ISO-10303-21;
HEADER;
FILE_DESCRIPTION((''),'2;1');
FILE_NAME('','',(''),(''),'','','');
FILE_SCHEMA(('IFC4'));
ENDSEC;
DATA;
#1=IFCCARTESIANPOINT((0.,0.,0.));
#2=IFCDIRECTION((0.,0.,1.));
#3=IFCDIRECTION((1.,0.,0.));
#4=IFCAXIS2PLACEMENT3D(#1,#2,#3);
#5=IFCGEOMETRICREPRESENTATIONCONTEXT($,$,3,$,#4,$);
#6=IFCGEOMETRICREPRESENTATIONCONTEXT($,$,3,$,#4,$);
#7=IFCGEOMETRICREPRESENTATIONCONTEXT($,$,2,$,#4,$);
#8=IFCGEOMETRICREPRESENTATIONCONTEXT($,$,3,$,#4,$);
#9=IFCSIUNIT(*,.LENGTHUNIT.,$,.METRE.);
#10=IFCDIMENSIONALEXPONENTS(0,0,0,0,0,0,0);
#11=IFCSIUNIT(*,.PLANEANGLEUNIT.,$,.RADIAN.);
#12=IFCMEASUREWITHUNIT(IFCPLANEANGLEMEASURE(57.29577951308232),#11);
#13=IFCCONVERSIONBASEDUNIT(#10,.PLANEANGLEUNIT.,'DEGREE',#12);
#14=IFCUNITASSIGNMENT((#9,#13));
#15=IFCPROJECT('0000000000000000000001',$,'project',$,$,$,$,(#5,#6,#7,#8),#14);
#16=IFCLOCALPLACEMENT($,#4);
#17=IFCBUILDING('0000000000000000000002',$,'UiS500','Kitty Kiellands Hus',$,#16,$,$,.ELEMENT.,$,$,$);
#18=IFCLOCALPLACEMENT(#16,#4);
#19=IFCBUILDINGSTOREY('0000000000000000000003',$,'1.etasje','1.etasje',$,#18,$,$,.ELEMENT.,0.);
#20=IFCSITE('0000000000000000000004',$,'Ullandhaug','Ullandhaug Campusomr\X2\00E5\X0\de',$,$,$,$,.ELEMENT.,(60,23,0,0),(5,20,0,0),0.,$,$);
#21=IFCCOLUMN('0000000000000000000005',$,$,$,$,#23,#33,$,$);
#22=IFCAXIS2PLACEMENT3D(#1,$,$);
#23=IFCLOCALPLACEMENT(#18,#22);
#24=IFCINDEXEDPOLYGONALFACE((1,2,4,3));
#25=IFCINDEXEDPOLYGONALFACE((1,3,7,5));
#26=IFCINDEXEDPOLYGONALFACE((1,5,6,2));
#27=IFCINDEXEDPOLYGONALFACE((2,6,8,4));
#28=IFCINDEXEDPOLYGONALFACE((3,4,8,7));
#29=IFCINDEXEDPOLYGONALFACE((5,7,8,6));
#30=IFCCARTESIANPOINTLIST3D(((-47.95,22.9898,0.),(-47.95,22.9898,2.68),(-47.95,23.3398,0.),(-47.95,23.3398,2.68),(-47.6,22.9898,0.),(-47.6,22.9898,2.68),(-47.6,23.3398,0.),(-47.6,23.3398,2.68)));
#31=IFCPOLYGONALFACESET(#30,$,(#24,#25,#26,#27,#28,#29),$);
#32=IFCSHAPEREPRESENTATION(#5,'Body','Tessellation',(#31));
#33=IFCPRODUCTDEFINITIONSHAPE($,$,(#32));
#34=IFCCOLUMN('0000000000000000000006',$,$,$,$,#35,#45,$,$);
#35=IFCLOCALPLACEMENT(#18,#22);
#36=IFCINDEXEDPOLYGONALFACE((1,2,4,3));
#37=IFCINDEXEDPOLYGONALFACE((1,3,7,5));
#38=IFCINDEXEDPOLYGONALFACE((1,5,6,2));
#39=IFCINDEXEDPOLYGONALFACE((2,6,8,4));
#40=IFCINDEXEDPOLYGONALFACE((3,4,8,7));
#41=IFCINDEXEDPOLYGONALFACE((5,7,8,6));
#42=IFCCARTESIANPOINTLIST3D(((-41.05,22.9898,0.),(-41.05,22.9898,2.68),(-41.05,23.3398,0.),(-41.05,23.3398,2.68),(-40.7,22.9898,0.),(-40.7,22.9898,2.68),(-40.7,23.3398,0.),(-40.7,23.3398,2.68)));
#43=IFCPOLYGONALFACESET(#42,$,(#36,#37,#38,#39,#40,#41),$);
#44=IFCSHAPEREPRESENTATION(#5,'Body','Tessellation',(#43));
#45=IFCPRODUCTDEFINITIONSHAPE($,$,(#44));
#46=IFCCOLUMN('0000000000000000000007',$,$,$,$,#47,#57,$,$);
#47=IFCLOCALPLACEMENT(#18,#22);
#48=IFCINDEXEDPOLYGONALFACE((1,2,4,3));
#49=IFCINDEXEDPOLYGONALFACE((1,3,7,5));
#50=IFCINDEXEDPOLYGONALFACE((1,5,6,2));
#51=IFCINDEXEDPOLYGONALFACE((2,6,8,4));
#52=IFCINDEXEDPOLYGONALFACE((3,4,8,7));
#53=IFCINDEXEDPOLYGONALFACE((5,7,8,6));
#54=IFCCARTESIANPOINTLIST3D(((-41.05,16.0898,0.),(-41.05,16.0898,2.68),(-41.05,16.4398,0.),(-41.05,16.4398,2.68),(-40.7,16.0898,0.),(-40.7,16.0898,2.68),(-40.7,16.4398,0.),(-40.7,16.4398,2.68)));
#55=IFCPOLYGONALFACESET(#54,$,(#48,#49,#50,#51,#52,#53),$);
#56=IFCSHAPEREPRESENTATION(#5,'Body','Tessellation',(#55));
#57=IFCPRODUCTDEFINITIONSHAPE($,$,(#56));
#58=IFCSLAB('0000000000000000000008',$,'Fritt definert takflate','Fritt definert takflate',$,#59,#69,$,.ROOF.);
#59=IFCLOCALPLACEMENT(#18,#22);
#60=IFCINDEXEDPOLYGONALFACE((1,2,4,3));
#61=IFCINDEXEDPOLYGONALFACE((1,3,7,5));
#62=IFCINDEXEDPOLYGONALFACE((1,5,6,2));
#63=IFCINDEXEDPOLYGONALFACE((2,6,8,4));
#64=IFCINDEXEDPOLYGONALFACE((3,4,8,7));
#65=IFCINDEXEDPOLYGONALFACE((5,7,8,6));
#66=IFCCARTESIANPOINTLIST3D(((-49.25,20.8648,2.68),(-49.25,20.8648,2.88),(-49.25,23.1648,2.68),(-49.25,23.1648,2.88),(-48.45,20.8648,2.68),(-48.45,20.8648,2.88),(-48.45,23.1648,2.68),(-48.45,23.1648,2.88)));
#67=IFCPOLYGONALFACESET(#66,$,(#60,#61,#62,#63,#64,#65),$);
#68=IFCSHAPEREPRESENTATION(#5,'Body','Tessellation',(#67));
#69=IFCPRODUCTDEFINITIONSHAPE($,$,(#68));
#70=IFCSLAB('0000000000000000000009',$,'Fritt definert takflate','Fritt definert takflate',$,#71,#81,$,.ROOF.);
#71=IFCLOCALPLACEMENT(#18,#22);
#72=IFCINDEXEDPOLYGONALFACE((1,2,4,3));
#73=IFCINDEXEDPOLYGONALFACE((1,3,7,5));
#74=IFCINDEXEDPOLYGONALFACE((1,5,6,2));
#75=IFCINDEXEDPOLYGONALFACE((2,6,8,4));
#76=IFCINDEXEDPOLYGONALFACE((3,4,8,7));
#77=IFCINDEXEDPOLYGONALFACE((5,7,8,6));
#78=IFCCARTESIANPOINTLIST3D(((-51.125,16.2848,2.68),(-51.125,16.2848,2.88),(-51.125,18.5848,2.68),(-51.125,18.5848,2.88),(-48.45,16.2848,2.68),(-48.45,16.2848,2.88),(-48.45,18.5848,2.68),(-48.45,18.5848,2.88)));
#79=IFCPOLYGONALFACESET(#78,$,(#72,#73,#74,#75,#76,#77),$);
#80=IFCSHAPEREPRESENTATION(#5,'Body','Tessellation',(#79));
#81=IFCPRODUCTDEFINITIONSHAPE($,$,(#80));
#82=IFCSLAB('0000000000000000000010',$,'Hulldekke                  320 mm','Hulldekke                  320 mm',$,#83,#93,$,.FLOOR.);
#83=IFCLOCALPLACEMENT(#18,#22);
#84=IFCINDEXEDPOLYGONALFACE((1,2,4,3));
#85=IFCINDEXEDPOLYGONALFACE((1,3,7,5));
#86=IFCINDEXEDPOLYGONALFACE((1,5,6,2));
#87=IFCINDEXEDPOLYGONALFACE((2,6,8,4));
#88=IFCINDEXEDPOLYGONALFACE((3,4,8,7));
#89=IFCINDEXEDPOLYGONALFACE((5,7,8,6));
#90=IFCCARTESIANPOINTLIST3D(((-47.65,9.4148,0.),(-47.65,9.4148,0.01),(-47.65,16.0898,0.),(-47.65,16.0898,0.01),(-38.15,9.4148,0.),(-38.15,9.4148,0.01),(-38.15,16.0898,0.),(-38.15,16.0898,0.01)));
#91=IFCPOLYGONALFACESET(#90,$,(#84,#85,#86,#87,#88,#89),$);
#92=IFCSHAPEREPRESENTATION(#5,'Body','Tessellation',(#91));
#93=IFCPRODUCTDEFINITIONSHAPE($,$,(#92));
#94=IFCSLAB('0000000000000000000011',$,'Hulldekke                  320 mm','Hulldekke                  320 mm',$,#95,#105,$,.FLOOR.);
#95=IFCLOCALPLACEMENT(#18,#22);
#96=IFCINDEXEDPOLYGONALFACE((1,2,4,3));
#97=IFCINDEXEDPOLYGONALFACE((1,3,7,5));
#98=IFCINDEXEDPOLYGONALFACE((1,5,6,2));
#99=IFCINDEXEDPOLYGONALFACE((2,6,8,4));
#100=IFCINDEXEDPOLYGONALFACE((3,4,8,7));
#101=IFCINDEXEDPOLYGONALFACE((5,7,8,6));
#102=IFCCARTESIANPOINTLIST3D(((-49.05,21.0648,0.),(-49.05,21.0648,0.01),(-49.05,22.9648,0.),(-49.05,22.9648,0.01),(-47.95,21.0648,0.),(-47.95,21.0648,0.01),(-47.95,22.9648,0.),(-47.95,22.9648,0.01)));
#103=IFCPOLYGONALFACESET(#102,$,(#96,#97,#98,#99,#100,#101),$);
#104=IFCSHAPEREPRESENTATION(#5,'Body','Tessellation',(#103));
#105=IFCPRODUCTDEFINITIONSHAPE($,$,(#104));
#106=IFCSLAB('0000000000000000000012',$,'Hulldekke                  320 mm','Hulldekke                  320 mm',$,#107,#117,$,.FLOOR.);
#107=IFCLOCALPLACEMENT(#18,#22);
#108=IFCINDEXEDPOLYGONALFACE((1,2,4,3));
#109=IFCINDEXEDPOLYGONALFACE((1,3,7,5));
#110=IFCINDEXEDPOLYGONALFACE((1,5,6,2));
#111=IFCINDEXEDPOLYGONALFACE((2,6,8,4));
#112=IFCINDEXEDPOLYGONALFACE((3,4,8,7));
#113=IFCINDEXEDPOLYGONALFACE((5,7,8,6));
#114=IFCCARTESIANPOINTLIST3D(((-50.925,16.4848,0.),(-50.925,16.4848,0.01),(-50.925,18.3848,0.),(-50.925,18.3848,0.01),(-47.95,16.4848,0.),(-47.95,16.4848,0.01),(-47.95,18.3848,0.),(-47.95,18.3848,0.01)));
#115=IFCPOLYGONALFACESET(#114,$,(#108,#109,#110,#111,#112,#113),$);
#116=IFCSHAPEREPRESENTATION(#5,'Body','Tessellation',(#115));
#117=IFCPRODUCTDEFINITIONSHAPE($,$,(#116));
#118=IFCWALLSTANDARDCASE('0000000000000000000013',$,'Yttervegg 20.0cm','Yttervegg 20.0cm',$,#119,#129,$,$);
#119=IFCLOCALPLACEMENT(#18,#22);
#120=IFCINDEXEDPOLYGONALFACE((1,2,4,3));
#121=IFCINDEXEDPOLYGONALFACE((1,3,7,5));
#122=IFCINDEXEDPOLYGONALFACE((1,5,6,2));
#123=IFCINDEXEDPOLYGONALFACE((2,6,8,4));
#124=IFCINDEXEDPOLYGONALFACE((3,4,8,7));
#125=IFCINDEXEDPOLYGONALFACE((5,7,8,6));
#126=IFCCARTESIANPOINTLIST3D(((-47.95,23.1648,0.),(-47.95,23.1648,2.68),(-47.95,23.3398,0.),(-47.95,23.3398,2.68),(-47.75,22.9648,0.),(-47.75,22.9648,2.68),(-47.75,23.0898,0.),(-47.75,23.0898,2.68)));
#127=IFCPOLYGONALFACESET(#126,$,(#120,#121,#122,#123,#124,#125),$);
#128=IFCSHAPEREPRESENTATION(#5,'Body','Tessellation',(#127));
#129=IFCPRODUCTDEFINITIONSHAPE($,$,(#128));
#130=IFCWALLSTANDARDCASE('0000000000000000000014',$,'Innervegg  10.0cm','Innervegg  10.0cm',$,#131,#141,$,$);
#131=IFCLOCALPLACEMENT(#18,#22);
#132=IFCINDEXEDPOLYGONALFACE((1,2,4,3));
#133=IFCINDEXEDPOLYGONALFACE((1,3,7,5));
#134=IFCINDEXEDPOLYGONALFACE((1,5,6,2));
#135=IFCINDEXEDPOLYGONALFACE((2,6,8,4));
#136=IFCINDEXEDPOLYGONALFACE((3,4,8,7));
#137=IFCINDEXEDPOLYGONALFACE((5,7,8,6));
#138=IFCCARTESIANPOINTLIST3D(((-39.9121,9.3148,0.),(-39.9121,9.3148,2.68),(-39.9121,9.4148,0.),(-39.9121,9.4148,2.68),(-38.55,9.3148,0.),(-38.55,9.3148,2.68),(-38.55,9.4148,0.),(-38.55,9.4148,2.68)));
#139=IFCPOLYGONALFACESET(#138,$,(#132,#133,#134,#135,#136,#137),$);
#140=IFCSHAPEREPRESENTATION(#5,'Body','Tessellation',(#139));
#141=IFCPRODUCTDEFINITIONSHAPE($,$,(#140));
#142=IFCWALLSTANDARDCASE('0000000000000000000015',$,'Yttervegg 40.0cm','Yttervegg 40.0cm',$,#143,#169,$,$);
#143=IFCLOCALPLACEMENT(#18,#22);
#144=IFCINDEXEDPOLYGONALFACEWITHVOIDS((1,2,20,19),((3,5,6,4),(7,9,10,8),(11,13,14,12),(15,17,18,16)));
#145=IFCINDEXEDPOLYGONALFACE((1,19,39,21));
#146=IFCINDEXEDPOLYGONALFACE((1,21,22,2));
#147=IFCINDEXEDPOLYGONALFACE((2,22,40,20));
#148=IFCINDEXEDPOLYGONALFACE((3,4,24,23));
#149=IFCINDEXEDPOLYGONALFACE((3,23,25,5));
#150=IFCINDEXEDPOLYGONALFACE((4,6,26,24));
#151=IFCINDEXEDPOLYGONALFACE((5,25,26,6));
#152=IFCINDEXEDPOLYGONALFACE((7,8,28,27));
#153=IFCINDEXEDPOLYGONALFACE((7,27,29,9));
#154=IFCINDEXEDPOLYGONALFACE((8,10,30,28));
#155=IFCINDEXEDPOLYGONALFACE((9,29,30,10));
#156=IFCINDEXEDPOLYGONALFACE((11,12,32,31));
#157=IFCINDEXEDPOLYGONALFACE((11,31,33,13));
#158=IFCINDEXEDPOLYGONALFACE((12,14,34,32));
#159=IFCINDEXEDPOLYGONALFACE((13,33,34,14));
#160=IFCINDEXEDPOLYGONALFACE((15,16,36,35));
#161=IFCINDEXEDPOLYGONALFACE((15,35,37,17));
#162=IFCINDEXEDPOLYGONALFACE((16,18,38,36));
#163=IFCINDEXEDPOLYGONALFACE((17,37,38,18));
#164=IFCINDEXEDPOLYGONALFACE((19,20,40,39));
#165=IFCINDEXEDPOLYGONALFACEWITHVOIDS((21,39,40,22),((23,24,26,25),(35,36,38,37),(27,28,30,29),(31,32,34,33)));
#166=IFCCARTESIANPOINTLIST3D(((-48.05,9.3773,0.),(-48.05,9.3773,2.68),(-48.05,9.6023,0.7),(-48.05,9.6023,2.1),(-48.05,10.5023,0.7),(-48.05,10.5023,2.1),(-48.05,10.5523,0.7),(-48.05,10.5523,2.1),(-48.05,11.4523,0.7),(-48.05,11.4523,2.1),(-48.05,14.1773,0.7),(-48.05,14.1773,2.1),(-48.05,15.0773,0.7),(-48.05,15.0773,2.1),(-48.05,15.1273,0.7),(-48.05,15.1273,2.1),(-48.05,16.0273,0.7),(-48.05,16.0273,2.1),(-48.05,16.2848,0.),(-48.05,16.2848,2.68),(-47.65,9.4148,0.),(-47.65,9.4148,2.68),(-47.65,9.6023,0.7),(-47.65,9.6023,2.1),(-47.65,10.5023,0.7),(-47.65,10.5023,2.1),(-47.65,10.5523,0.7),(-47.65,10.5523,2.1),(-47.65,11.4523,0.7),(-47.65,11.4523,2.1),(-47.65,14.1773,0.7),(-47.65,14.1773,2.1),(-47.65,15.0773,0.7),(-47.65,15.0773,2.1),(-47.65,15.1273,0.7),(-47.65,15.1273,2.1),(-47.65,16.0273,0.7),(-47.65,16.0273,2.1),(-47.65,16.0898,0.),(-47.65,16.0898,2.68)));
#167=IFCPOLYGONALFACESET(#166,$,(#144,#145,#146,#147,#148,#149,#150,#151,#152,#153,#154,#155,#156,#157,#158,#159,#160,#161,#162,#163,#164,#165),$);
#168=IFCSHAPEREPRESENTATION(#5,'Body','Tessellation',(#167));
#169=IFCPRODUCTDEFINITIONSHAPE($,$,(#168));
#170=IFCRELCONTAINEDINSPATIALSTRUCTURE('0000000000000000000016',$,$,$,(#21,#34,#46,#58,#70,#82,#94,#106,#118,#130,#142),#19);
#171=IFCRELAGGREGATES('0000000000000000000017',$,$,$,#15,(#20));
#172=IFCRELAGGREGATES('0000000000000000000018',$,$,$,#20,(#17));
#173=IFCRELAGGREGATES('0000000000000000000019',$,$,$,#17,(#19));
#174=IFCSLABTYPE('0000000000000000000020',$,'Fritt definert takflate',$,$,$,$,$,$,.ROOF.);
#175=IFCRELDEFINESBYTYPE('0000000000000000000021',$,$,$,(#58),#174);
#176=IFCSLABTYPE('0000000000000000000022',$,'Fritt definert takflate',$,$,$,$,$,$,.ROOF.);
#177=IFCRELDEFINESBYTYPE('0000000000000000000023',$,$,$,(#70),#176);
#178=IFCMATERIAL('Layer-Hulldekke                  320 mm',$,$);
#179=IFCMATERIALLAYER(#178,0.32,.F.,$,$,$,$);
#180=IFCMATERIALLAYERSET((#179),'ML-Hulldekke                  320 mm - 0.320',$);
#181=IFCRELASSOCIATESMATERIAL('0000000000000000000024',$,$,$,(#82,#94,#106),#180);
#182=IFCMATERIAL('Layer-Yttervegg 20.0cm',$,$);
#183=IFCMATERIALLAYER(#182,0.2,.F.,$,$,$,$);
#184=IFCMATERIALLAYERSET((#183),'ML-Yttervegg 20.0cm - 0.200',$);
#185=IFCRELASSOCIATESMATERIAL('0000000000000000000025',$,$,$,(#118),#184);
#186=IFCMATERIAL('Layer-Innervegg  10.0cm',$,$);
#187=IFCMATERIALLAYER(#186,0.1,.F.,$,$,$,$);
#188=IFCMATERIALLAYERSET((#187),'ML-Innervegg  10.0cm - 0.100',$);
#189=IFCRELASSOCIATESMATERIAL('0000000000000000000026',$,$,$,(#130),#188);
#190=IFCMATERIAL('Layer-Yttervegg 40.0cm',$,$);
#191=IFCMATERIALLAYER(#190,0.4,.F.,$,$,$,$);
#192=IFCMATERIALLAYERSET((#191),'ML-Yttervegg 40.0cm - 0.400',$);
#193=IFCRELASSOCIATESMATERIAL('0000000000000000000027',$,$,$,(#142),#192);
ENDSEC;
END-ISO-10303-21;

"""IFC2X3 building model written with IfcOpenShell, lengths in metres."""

from ifc_helpers import new_model, entity, si_unit, converted_unit, frame, origin_with_axes, origin_2d_with_axis, place, context, project, spatial, polyline, rectangle, outline, extrude, material, layer, layer_set, layer_usage, type_object, element, save


model = new_model("IFC2X3")

# Units and contexts
context_of_model_1 = context(None, 3, world=origin_with_axes())
context_of_model_2 = context(None, 3, world=origin_with_axes())
context_of_model_3 = context(None, 2, world=origin_with_axes())
context_of_model_4 = context(None, 3, world=origin_with_axes())
ifc_project = project(units=[si_unit("LENGTHUNIT", "METRE"), converted_unit("PLANEANGLEUNIT", "DEGREE", entity("IfcPlaneAngleMeasure", 57.29577951308232), si_unit("PLANEANGLEUNIT", "RADIAN"), dimensions=[0, 0, 0, 0, 0, 0, 0])], contexts=[context_of_model_1, context_of_model_2, context_of_model_3, context_of_model_4])

# Site, building, storey
site = spatial("IfcSite", under=ifc_project, Name="Ullandhaug", Description="Ullandhaug Campusområde", CompositionType="ELEMENT", RefLatitude=(60, 23, 0, 0), RefLongitude=(5, 20, 0, 0), RefElevation=0.0)
building_placement = place(None, origin_with_axes())
building = spatial("IfcBuilding", under=site, at=building_placement, Name="UiS500", Description="Kitty Kiellands Hus", CompositionType="ELEMENT")
storey_placement = place(building_placement, origin_with_axes())
storey = spatial("IfcBuildingStorey", under=building, at=storey_placement, Name="1.etasje", Description="1.etasje", CompositionType="ELEMENT", Elevation=0.0)

# Columns
for number, where, z_axis, x_axis in (
    (1, (-47.775, 23.1648, 0.0), (0.0, 0.0, 1.0), (1.0, 0.0, 0.0)),
    (2, (-40.875, 23.1648, 0.0), (0.0, 0.0, 1.0), (1.0, 0.0, 0.0)),
    (3, (-40.875, 16.2648, 0.0), (0.0, 0.0, 1.0), (1.0, 0.0, 0.0)),
):
    element("IfcColumn", number, at=place(storey_placement, frame(where, z_axis=z_axis, x_axis=x_axis)), inside=storey, context=context_of_model_1, shape_type="SweptSolid", body=[
        extrude(rectangle(XDim=0.35, YDim=0.35, at=origin_2d_with_axis()), origin_with_axes(), (0.0, 0.0, 1.0), 2.68),
    ])

# Slabs
slab_type_1 = type_object("IfcSlabType", Name="Fritt definert takflate", PredefinedType="ROOF")
slab_1_placement = place(storey_placement, frame((-48.45, 23.1648, 2.68), z_axis=(0.0, 0.0, 1.0), x_axis=(-1.0, 0.0, 0.0)))
element("IfcSlab", 4, at=slab_1_placement, inside=storey, type_object=slab_type_1, Name="Fritt definert takflate", Description="Fritt definert takflate", PredefinedType="ROOF", context=context_of_model_1, shape_type="SweptSolid", body=[
    extrude(outline(polyline([(0.0, 0.0), (0.8, 0.0), (0.8, 2.3), (0.0, 2.3), (0.0, 0.0)])), origin_with_axes(), (0.0, 0.0, 1.0), 0.2),
])
slab_type_2 = type_object("IfcSlabType", Name="Fritt definert takflate", PredefinedType="ROOF")
slab_2_placement = place(storey_placement, frame((-48.45, 18.5848, 2.68), z_axis=(0.0, 0.0, 1.0), x_axis=(-1.0, 0.0, 0.0)))
element("IfcSlab", 5, at=slab_2_placement, inside=storey, type_object=slab_type_2, Name="Fritt definert takflate", Description="Fritt definert takflate", PredefinedType="ROOF", context=context_of_model_1, shape_type="SweptSolid", body=[
    extrude(outline(polyline([(0.0, 0.0), (2.675, 0.0), (2.675, 2.3), (0.0, 2.3), (0.0, 0.0)])), origin_with_axes(), (0.0, 0.0, 1.0), 0.2),
])
ifc_material_1 = material(Name="Layer-Hulldekke                  320 mm")
ifc_layer_1 = layer(ifc_material_1, 0.32, ventilated=False)
ifc_layer_set_1 = layer_set([ifc_layer_1], Name="ML-Hulldekke                  320 mm - 0.320")
ifc_layer_usage_1 = layer_usage(ifc_layer_set_1, "AXIS2", "POSITIVE", 0.0)
slab_3_placement = place(storey_placement, frame((-47.65, 16.0898, 0.0), z_axis=(0.0, 0.0, 1.0), x_axis=(1.0, 0.0, 0.0)))
element("IfcSlab", 6, at=slab_3_placement, inside=storey, material=ifc_layer_usage_1, Name="Hulldekke                  320 mm", Description="Hulldekke                  320 mm", PredefinedType="FLOOR", context=context_of_model_1, shape_type="SweptSolid", body=[
    extrude(outline(polyline([(0.0, 0.0), (6.675, 0.0), (6.675, 9.5), (0.0, 9.5), (0.0, 0.0)])), frame((0.0, 0.0, 0.0), z_axis=(0.0, 0.0, 1.0), x_axis=(0.0, -1.0, 0.0)), (0.0, 0.0, 1.0), 0.01),
])
slab_4_placement = place(storey_placement, frame((-49.05, 22.9648, 0.0), z_axis=(0.0, 0.0, 1.0), x_axis=(1.0, 0.0, 0.0)))
element("IfcSlab", 7, at=slab_4_placement, inside=storey, material=ifc_layer_usage_1, Name="Hulldekke                  320 mm", Description="Hulldekke                  320 mm", PredefinedType="FLOOR", context=context_of_model_1, shape_type="SweptSolid", body=[
    extrude(outline(polyline([(0.0, 0.0), (1.9, 0.0), (1.9, 1.1), (0.0, 1.1), (0.0, 0.0)])), frame((0.0, 0.0, 0.0), z_axis=(0.0, 0.0, 1.0), x_axis=(0.0, -1.0, 0.0)), (0.0, 0.0, 1.0), 0.01),
])
slab_5_placement = place(storey_placement, frame((-50.925, 16.4848, 0.0), z_axis=(0.0, 0.0, 1.0), x_axis=(1.0, 0.0, 0.0)))
element("IfcSlab", 8, at=slab_5_placement, inside=storey, material=ifc_layer_usage_1, Name="Hulldekke                  320 mm", Description="Hulldekke                  320 mm", PredefinedType="FLOOR", context=context_of_model_1, shape_type="SweptSolid", body=[
    extrude(outline(polyline([(0.0, 0.0), (2.975, 0.0), (2.975, 1.9), (0.0, 1.9), (0.0, 0.0)])), origin_with_axes(), (0.0, 0.0, 1.0), 0.01),
])

# Walls
ifc_material_2 = material(Name="Layer-Yttervegg 20.0cm")
ifc_layer_2 = layer(ifc_material_2, 0.2, ventilated=False)
ifc_layer_set_2 = layer_set([ifc_layer_2], Name="ML-Yttervegg 20.0cm - 0.200")
ifc_layer_usage_2 = layer_usage(ifc_layer_set_2, "AXIS2", "POSITIVE", 0.0)
wall_1_placement = place(storey_placement, frame((-47.95, 23.3398, 0.0), z_axis=(0.0, 0.0, 1.0), x_axis=(0.0, -1.0, 0.0)))
element("IfcWallStandardCase", 9, at=wall_1_placement, inside=storey, material=ifc_layer_usage_2, Name="Yttervegg 20.0cm", Description="Yttervegg 20.0cm", context=context_of_model_1, shape_type="SweptSolid", body=[
    extrude(outline(polyline([(0.0, 0.0), (0.175, 0.0), (0.375, 0.2), (0.25, 0.2), (0.0, 0.0)])), frame((0.0, 0.0, 0.0), z_axis=(0.0, 0.0, 1.0), x_axis=(1.0, 0.0, 0.0)), (0.0, 0.0, 1.0), 2.68),
])
ifc_material_3 = material(Name="Layer-Innervegg  10.0cm")
ifc_layer_3 = layer(ifc_material_3, 0.1, ventilated=False)
ifc_layer_set_3 = layer_set([ifc_layer_3], Name="ML-Innervegg  10.0cm - 0.100")
ifc_layer_usage_3 = layer_usage(ifc_layer_set_3, "AXIS2", "POSITIVE", 0.0)
wall_2_placement = place(storey_placement, frame((-38.55, 9.4148, 0.0), z_axis=(0.0, 0.0, 1.0), x_axis=(-1.0, 0.0, 0.0)))
element("IfcWallStandardCase", 10, at=wall_2_placement, inside=storey, material=ifc_layer_usage_3, Name="Innervegg  10.0cm", Description="Innervegg  10.0cm", context=context_of_model_1, shape_type="SweptSolid", body=[
    extrude(outline(polyline([(0.0, 0.0), (1.3621, 0.0), (1.3621, 0.1), (0.0, 0.1), (0.0, 0.0)])), frame((0.0, 0.0, 0.0), z_axis=(0.0, 0.0, 1.0), x_axis=(1.0, 0.0, 0.0)), (0.0, 0.0, 1.0), 2.68),
])

# Wall, openings
ifc_material_4 = material(Name="Layer-Yttervegg 40.0cm")
ifc_layer_4 = layer(ifc_material_4, 0.4, ventilated=False)
ifc_layer_set_4 = layer_set([ifc_layer_4], Name="ML-Yttervegg 40.0cm - 0.400")
ifc_layer_usage_4 = layer_usage(ifc_layer_set_4, "AXIS2", "POSITIVE", 0.0)
wall_3_placement = place(storey_placement, frame((-48.05, 16.2848, 0.0), z_axis=(0.0, 0.0, 1.0), x_axis=(0.0, -1.0, 0.0)))
wall_3 = element("IfcWallStandardCase", 11, at=wall_3_placement, inside=storey, material=ifc_layer_usage_4, Name="Yttervegg 40.0cm", Description="Yttervegg 40.0cm", context=context_of_model_1, shape_type="SweptSolid", body=[
    extrude(outline(polyline([(0.0, 0.0), (6.9075, 0.0), (6.87, 0.4), (0.195, 0.4), (0.0, 0.0)])), frame((0.0, 0.0, 0.0), z_axis=(0.0, 0.0, 1.0), x_axis=(1.0, 0.0, 0.0)), (0.0, 0.0, 1.0), 2.68),
])
opening_1_placement = place(wall_3_placement, frame((5.7825, 0.4, 0.7), z_axis=(0.0, 0.0, 1.0), x_axis=(1.0, 0.0, 0.0)))
element("IfcOpeningElement", 12, at=opening_1_placement, cuts=wall_3, context=context_of_model_1, shape_type="SweptSolid", body=[
    extrude(outline(polyline([(0.0, 0.0), (1.4, 0.0), (1.4, 0.9), (0.0, 0.9), (0.0, 0.0)])), frame((0.0, 0.0, 0.0), z_axis=(0.0, 1.0, 0.0), x_axis=(0.0, 0.0, 1.0)), (0.0, 0.0, -1.0), 0.4),
])
opening_2_placement = place(wall_3_placement, frame((4.8325, 0.4, 0.7), z_axis=(0.0, 0.0, 1.0), x_axis=(1.0, 0.0, 0.0)))
element("IfcOpeningElement", 13, at=opening_2_placement, cuts=wall_3, context=context_of_model_1, shape_type="SweptSolid", body=[
    extrude(outline(polyline([(0.0, 0.0), (1.4, 0.0), (1.4, 0.9), (0.0, 0.9), (0.0, 0.0)])), frame((0.0, 0.0, 0.0), z_axis=(0.0, 1.0, 0.0), x_axis=(0.0, 0.0, 1.0)), (0.0, 0.0, -1.0), 0.4),
])
opening_3_placement = place(wall_3_placement, frame((1.2075, 0.4, 0.7), z_axis=(0.0, 0.0, 1.0), x_axis=(1.0, 0.0, 0.0)))
element("IfcOpeningElement", 14, at=opening_3_placement, cuts=wall_3, context=context_of_model_1, shape_type="SweptSolid", body=[
    extrude(outline(polyline([(0.0, 0.0), (1.4, 0.0), (1.4, 0.9), (0.0, 0.9), (0.0, 0.0)])), frame((0.0, 0.0, 0.0), z_axis=(0.0, 1.0, 0.0), x_axis=(0.0, 0.0, 1.0)), (0.0, 0.0, -1.0), 0.4),
])
opening_4_placement = place(wall_3_placement, frame((0.2575, 0.4, 0.7), z_axis=(0.0, 0.0, 1.0), x_axis=(1.0, 0.0, 0.0)))
element("IfcOpeningElement", 15, at=opening_4_placement, cuts=wall_3, context=context_of_model_1, shape_type="SweptSolid", body=[
    extrude(outline(polyline([(0.0, 0.0), (1.4, 0.0), (1.4, 0.9), (0.0, 0.9), (0.0, 0.0)])), frame((0.0, 0.0, 0.0), z_axis=(0.0, 1.0, 0.0), x_axis=(0.0, 0.0, 1.0)), (0.0, 0.0, -1.0), 0.4),
])

save(model, "model.ifc")
